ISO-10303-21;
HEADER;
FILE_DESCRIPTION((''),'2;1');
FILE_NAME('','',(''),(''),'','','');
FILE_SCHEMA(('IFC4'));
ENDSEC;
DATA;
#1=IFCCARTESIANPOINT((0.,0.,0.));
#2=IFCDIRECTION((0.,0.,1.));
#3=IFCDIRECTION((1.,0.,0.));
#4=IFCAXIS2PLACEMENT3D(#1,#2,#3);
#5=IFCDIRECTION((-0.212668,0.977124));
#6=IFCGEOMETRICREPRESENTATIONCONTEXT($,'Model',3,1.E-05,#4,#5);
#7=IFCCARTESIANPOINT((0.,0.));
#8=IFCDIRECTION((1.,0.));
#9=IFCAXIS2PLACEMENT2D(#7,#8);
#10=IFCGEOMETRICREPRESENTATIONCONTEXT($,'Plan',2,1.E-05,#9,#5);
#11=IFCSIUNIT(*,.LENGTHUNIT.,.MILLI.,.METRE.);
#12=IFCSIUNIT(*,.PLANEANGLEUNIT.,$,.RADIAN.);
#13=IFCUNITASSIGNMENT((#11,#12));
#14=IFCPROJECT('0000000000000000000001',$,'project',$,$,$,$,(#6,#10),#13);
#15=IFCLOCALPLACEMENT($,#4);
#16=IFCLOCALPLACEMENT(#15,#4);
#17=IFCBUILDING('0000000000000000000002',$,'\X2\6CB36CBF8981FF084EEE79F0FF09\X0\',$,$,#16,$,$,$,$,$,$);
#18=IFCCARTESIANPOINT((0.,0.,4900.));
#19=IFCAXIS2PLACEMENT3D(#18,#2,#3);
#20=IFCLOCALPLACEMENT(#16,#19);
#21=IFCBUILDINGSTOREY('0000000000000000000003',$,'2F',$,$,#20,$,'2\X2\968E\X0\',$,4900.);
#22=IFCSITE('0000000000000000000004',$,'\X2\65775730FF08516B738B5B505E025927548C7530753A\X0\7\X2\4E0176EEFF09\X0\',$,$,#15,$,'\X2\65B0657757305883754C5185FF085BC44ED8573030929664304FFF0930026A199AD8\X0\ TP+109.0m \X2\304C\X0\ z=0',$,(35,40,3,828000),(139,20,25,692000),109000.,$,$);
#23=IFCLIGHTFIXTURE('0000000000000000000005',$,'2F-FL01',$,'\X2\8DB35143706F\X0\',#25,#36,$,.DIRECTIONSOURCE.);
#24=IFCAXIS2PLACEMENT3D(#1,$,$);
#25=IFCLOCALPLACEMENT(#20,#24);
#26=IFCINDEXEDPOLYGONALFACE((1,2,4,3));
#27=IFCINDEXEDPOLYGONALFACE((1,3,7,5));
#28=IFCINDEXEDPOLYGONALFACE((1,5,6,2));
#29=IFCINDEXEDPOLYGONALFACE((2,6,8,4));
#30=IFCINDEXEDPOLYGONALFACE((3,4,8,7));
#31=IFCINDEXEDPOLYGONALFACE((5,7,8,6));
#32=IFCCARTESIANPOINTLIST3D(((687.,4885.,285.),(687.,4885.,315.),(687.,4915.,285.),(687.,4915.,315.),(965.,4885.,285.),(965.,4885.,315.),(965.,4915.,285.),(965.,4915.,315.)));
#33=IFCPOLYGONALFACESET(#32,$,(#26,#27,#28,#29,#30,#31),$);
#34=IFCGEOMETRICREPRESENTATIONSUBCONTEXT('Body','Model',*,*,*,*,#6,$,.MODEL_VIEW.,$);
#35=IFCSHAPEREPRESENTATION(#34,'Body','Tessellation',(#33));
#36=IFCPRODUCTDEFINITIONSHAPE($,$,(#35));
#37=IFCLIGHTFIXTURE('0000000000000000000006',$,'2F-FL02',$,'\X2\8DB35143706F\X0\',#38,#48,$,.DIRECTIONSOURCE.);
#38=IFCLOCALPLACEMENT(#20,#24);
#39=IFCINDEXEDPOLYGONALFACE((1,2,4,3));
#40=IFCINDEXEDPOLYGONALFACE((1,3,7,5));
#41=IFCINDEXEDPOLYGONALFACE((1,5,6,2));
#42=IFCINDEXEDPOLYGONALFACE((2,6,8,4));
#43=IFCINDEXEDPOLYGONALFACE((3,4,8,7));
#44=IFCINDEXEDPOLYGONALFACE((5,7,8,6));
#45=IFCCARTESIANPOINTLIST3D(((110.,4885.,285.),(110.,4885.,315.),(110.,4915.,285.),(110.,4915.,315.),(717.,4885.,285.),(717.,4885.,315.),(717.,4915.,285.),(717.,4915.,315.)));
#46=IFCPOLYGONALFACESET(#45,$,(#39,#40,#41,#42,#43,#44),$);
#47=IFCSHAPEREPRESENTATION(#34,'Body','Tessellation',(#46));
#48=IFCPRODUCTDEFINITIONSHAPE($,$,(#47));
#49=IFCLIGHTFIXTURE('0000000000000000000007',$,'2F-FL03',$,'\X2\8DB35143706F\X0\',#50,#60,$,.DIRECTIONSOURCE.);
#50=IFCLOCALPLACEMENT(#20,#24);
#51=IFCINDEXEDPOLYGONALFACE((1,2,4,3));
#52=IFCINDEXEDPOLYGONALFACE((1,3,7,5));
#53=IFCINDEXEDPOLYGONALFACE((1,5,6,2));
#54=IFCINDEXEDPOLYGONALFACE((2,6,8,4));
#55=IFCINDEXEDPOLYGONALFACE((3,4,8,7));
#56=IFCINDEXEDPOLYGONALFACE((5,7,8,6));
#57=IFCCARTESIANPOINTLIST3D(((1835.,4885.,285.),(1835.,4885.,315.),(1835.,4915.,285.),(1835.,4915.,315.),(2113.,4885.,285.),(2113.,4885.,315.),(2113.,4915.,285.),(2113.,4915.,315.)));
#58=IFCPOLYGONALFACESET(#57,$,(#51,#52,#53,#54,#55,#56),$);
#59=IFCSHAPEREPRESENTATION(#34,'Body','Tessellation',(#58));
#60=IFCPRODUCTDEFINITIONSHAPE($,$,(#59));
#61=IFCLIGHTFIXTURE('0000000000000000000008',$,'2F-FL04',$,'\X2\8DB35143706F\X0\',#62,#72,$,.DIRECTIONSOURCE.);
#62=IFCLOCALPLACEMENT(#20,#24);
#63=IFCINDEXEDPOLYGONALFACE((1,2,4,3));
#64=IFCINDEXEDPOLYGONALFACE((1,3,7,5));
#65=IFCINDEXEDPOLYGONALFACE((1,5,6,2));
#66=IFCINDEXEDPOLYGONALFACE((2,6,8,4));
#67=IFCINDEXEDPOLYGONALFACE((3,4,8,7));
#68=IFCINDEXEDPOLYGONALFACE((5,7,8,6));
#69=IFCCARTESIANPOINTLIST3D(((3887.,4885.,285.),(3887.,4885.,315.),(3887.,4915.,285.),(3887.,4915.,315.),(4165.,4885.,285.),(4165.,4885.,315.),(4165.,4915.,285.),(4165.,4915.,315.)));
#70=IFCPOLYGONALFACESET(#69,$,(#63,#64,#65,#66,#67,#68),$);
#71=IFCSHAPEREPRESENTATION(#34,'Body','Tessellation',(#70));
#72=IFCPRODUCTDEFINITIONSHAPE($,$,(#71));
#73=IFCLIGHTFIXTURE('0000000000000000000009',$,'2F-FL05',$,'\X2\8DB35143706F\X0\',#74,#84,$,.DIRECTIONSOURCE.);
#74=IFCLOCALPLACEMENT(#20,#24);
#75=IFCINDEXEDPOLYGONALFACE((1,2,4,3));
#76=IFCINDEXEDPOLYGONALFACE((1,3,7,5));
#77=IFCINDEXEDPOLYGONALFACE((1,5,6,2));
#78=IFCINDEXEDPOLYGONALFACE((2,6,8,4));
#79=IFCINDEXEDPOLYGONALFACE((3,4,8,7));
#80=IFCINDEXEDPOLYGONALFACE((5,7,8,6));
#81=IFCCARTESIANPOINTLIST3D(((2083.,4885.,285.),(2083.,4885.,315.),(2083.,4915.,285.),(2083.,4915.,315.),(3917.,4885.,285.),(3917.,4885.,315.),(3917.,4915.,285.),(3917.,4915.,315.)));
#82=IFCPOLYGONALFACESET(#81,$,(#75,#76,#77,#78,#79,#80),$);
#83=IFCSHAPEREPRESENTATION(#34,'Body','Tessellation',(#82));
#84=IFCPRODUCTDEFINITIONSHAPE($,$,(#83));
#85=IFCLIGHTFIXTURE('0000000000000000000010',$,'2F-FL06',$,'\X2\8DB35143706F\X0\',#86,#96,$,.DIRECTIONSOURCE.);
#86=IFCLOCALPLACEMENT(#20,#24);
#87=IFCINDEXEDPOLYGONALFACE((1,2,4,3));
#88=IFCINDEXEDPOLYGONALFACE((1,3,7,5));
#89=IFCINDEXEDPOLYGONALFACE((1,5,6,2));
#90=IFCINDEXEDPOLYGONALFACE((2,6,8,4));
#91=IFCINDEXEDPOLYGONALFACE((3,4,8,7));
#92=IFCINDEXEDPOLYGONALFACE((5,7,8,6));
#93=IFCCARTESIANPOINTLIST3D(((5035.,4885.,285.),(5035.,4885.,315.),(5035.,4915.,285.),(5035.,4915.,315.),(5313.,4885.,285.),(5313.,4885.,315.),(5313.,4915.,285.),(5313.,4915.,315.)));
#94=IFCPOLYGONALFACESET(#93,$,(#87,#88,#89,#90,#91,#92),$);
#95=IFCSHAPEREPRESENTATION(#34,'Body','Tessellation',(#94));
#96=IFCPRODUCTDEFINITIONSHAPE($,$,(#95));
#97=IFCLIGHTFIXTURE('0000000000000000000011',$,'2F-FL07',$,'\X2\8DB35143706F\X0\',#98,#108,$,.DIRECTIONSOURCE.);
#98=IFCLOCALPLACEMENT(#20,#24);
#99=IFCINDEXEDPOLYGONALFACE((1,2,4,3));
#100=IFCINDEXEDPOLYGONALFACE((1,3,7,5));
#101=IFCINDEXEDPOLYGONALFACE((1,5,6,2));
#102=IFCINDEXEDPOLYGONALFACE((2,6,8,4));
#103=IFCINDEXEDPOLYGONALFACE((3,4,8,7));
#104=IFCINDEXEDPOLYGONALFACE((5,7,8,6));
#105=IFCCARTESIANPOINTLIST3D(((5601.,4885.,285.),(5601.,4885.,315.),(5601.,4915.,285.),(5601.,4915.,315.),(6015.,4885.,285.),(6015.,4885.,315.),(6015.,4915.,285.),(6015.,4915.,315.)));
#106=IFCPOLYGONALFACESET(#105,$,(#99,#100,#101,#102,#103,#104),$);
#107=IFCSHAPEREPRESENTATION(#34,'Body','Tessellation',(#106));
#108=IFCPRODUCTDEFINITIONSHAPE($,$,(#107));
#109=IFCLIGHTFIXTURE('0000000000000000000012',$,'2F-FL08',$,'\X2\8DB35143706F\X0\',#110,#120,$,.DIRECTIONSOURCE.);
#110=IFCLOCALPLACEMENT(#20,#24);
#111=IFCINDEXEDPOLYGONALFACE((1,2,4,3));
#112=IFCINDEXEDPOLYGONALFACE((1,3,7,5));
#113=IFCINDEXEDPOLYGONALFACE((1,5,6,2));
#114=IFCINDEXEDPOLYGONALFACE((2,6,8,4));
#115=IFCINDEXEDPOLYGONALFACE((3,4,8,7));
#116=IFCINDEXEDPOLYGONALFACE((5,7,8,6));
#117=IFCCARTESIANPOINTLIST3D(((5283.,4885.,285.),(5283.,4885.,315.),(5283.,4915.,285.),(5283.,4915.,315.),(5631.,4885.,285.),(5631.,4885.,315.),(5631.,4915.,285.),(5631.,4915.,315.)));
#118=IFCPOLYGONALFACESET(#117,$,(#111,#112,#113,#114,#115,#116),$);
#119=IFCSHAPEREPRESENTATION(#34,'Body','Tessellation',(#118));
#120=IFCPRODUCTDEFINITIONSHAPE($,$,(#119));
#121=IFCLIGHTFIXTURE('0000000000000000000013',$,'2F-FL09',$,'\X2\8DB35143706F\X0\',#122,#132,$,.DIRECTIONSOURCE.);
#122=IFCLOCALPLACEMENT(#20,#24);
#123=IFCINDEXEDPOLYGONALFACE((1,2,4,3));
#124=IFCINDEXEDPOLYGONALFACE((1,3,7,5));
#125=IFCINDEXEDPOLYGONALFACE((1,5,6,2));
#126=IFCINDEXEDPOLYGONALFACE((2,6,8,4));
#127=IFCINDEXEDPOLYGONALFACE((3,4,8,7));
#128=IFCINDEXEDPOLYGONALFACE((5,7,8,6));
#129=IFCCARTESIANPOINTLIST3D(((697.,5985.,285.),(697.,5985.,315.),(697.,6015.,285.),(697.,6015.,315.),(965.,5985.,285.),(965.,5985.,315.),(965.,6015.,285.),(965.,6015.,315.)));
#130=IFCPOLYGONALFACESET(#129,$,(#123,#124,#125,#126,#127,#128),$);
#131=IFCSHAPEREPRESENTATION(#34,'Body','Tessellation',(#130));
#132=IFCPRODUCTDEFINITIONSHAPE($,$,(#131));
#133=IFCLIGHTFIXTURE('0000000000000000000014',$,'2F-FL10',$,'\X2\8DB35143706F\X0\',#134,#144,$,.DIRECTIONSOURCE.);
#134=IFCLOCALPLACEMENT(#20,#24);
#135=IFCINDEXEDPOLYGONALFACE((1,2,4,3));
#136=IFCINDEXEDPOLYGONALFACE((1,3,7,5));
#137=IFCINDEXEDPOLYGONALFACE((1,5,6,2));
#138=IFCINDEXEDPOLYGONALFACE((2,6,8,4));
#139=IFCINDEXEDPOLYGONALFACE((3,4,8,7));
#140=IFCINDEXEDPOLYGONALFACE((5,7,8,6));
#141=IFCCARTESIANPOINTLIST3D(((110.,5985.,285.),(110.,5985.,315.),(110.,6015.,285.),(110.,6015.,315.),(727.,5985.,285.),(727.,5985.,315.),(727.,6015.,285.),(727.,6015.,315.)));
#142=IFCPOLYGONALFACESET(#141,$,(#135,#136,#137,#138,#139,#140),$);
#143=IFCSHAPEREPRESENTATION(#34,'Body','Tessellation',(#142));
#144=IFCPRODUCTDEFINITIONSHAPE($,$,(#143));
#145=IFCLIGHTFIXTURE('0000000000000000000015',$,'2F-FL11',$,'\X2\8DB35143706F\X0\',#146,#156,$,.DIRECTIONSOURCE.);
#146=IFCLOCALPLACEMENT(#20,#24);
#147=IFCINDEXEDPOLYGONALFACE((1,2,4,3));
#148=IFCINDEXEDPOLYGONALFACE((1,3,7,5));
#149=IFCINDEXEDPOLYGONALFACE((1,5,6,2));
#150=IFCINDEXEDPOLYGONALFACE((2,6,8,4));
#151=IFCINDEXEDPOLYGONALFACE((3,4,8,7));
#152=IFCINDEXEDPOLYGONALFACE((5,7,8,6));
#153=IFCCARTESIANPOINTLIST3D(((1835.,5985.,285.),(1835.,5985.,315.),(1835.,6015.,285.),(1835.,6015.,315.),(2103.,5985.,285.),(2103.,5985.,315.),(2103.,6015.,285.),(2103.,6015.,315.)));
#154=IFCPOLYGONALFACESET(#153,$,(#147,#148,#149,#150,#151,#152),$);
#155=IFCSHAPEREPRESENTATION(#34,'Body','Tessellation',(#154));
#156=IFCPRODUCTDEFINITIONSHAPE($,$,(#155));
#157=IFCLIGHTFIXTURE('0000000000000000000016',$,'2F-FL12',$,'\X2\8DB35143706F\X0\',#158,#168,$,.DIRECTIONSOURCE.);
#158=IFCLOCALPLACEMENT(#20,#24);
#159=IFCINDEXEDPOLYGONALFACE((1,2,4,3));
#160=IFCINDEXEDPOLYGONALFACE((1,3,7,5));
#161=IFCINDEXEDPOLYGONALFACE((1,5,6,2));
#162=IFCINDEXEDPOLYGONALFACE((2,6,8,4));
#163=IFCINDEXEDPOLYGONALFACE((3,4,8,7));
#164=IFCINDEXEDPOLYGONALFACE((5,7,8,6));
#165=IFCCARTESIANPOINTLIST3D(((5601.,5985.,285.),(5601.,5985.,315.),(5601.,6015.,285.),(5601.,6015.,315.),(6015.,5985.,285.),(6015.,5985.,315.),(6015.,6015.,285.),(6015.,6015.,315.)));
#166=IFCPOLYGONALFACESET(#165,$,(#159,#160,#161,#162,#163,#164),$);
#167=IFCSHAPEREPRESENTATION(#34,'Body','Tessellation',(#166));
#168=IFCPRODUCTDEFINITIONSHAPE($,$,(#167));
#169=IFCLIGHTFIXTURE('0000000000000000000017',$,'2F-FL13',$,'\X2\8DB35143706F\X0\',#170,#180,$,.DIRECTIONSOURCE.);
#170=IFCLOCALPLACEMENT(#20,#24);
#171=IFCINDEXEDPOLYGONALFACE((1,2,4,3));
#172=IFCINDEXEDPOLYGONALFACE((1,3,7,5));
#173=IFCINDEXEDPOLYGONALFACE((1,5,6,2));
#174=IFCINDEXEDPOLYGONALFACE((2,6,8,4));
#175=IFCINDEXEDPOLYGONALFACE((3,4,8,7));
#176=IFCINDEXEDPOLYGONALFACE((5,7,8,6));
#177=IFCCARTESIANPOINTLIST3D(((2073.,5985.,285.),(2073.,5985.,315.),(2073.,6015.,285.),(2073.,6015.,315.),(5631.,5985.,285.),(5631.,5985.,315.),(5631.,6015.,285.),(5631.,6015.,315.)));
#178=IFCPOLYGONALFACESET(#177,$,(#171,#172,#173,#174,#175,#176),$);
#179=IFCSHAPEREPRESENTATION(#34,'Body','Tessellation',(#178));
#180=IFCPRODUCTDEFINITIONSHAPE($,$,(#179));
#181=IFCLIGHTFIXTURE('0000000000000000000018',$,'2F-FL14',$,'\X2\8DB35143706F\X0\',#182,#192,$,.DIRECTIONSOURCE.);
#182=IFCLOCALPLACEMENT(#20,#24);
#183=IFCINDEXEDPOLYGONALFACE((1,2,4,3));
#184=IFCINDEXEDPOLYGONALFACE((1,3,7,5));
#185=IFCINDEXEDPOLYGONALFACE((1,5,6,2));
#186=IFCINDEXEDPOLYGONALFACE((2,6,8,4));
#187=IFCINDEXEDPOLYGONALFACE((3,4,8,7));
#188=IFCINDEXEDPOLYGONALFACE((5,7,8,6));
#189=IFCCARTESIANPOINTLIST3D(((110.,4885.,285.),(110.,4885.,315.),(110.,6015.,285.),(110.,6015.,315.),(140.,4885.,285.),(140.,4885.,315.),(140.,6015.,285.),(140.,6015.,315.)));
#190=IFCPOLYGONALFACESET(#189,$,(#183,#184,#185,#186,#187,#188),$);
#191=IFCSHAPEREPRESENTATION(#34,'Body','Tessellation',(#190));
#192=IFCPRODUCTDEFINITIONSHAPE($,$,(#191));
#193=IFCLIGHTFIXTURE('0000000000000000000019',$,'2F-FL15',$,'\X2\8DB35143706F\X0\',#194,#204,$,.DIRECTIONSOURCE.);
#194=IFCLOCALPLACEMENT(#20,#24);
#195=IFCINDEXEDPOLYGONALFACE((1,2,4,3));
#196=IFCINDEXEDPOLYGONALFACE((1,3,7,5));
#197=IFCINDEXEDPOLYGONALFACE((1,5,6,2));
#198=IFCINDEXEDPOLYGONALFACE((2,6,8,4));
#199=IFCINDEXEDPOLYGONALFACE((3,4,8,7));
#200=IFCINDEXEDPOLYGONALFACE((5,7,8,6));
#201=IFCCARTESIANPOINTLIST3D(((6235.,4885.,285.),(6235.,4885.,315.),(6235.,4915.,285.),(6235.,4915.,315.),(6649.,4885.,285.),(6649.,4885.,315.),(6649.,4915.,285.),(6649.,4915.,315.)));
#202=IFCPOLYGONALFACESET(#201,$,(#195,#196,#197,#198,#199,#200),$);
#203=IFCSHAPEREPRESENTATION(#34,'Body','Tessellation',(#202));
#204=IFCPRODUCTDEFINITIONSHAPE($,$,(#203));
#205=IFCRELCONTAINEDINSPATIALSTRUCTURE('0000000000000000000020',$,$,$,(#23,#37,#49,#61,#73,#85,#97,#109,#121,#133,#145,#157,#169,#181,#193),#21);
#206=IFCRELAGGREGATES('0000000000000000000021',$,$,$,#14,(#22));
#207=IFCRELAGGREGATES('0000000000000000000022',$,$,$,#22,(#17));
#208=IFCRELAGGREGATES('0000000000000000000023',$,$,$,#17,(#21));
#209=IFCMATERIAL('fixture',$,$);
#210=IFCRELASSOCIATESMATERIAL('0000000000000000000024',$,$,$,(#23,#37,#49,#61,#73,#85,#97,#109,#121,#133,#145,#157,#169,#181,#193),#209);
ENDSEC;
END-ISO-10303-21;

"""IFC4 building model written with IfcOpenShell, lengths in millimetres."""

from ifc_helpers import new_model, si_unit, direction, frame, frame_2d, origin_with_axes, origin_2d_with_axis, place, context, subcontext, project, spatial, rectangle, extrude, material, element, save


model = new_model("IFC4")

# Units and contexts
model_context = context("Model", 3, precision=1e-05, world=origin_with_axes(), true_north=direction((-0.212668, 0.977124)))
plan_context = context("Plan", 2, precision=1e-05, world=origin_2d_with_axis(), true_north=direction((-0.212668, 0.977124)))
body_context = subcontext(model_context, "Body", "Model", "MODEL_VIEW")
ifc_project = project(units=[si_unit("LENGTHUNIT", "METRE", prefix="MILLI"), si_unit("PLANEANGLEUNIT", "RADIAN")], contexts=[model_context, plan_context])

# Site, building, storey
site_placement = place(None, origin_with_axes())
site = spatial("IfcSite", under=ifc_project, at=site_placement, Name="敷地（八王子市大和田町7丁目）", LongName="新敷地境界内（寄付地を除く）。標高 TP+109.0m が z=0", RefLatitude=(35, 40, 3, 828000), RefLongitude=(139, 20, 25, 692000), RefElevation=109000.0)
building_placement = place(site_placement, origin_with_axes())
building = spatial("IfcBuilding", under=site, at=building_placement, Name="河沿要（仮称）")
storey_placement = place(building_placement, frame((0.0, 0.0, 4900.0), z_axis=(0.0, 0.0, 1.0), x_axis=(1.0, 0.0, 0.0)))
storey = spatial("IfcBuildingStorey", under=building, at=storey_placement, Name="2F", LongName="2階", Elevation=4900.0)

# Light fixtures
ifc_material = material(Name="fixture")
light_fixture_1_placement = place(storey_placement, origin_with_axes())
element("IfcLightFixture", 1, at=light_fixture_1_placement, inside=storey, material=ifc_material, Name="2F-FL01", ObjectType="足元灯", PredefinedType="DIRECTIONSOURCE", context=body_context, shape_type="SweptSolid", body=[
    extrude(rectangle(XDim=278.0, YDim=30.0, at=frame_2d((826.0, 4900.0))), frame((0.0, 0.0, 285.0)), (0.0, 0.0, 1.0), 30.0),
])
light_fixture_2_placement = place(storey_placement, origin_with_axes())
element("IfcLightFixture", 2, at=light_fixture_2_placement, inside=storey, material=ifc_material, Name="2F-FL02", ObjectType="足元灯", PredefinedType="DIRECTIONSOURCE", context=body_context, shape_type="SweptSolid", body=[
    extrude(rectangle(XDim=607.0, YDim=30.0, at=frame_2d((413.5, 4900.0))), frame((0.0, 0.0, 285.0)), (0.0, 0.0, 1.0), 30.0),
])
light_fixture_3_placement = place(storey_placement, origin_with_axes())
element("IfcLightFixture", 3, at=light_fixture_3_placement, inside=storey, material=ifc_material, Name="2F-FL03", ObjectType="足元灯", PredefinedType="DIRECTIONSOURCE", context=body_context, shape_type="SweptSolid", body=[
    extrude(rectangle(XDim=278.0, YDim=30.0, at=frame_2d((1974.0, 4900.0))), frame((0.0, 0.0, 285.0)), (0.0, 0.0, 1.0), 30.0),
])
light_fixture_4_placement = place(storey_placement, origin_with_axes())
element("IfcLightFixture", 4, at=light_fixture_4_placement, inside=storey, material=ifc_material, Name="2F-FL04", ObjectType="足元灯", PredefinedType="DIRECTIONSOURCE", context=body_context, shape_type="SweptSolid", body=[
    extrude(rectangle(XDim=278.0, YDim=30.0, at=frame_2d((4026.0, 4900.0))), frame((0.0, 0.0, 285.0)), (0.0, 0.0, 1.0), 30.0),
])
light_fixture_5_placement = place(storey_placement, origin_with_axes())
element("IfcLightFixture", 5, at=light_fixture_5_placement, inside=storey, material=ifc_material, Name="2F-FL05", ObjectType="足元灯", PredefinedType="DIRECTIONSOURCE", context=body_context, shape_type="SweptSolid", body=[
    extrude(rectangle(XDim=1834.0, YDim=30.0, at=frame_2d((3000.0, 4900.0))), frame((0.0, 0.0, 285.0)), (0.0, 0.0, 1.0), 30.0),
])
light_fixture_6_placement = place(storey_placement, origin_with_axes())
element("IfcLightFixture", 6, at=light_fixture_6_placement, inside=storey, material=ifc_material, Name="2F-FL06", ObjectType="足元灯", PredefinedType="DIRECTIONSOURCE", context=body_context, shape_type="SweptSolid", body=[
    extrude(rectangle(XDim=278.0, YDim=30.0, at=frame_2d((5174.0, 4900.0))), frame((0.0, 0.0, 285.0)), (0.0, 0.0, 1.0), 30.0),
])
light_fixture_7_placement = place(storey_placement, origin_with_axes())
element("IfcLightFixture", 7, at=light_fixture_7_placement, inside=storey, material=ifc_material, Name="2F-FL07", ObjectType="足元灯", PredefinedType="DIRECTIONSOURCE", context=body_context, shape_type="SweptSolid", body=[
    extrude(rectangle(XDim=414.0, YDim=30.0, at=frame_2d((5808.0, 4900.0))), frame((0.0, 0.0, 285.0)), (0.0, 0.0, 1.0), 30.0),
])
light_fixture_8_placement = place(storey_placement, origin_with_axes())
element("IfcLightFixture", 8, at=light_fixture_8_placement, inside=storey, material=ifc_material, Name="2F-FL08", ObjectType="足元灯", PredefinedType="DIRECTIONSOURCE", context=body_context, shape_type="SweptSolid", body=[
    extrude(rectangle(XDim=348.0, YDim=30.0, at=frame_2d((5457.0, 4900.0))), frame((0.0, 0.0, 285.0)), (0.0, 0.0, 1.0), 30.0),
])
light_fixture_9_placement = place(storey_placement, origin_with_axes())
element("IfcLightFixture", 9, at=light_fixture_9_placement, inside=storey, material=ifc_material, Name="2F-FL09", ObjectType="足元灯", PredefinedType="DIRECTIONSOURCE", context=body_context, shape_type="SweptSolid", body=[
    extrude(rectangle(XDim=268.0, YDim=30.0, at=frame_2d((831.0, 6000.0))), frame((0.0, 0.0, 285.0)), (0.0, 0.0, 1.0), 30.0),
])
light_fixture_10_placement = place(storey_placement, origin_with_axes())
element("IfcLightFixture", 10, at=light_fixture_10_placement, inside=storey, material=ifc_material, Name="2F-FL10", ObjectType="足元灯", PredefinedType="DIRECTIONSOURCE", context=body_context, shape_type="SweptSolid", body=[
    extrude(rectangle(XDim=617.0, YDim=30.0, at=frame_2d((418.5, 6000.0))), frame((0.0, 0.0, 285.0)), (0.0, 0.0, 1.0), 30.0),
])
light_fixture_11_placement = place(storey_placement, origin_with_axes())
element("IfcLightFixture", 11, at=light_fixture_11_placement, inside=storey, material=ifc_material, Name="2F-FL11", ObjectType="足元灯", PredefinedType="DIRECTIONSOURCE", context=body_context, shape_type="SweptSolid", body=[
    extrude(rectangle(XDim=268.0, YDim=30.0, at=frame_2d((1969.0, 6000.0))), frame((0.0, 0.0, 285.0)), (0.0, 0.0, 1.0), 30.0),
])
light_fixture_12_placement = place(storey_placement, origin_with_axes())
element("IfcLightFixture", 12, at=light_fixture_12_placement, inside=storey, material=ifc_material, Name="2F-FL12", ObjectType="足元灯", PredefinedType="DIRECTIONSOURCE", context=body_context, shape_type="SweptSolid", body=[
    extrude(rectangle(XDim=414.0, YDim=30.0, at=frame_2d((5808.0, 6000.0))), frame((0.0, 0.0, 285.0)), (0.0, 0.0, 1.0), 30.0),
])
light_fixture_13_placement = place(storey_placement, origin_with_axes())
element("IfcLightFixture", 13, at=light_fixture_13_placement, inside=storey, material=ifc_material, Name="2F-FL13", ObjectType="足元灯", PredefinedType="DIRECTIONSOURCE", context=body_context, shape_type="SweptSolid", body=[
    extrude(rectangle(XDim=3558.0, YDim=30.0, at=frame_2d((3852.0, 6000.0))), frame((0.0, 0.0, 285.0)), (0.0, 0.0, 1.0), 30.0),
])
light_fixture_14_placement = place(storey_placement, origin_with_axes())
element("IfcLightFixture", 14, at=light_fixture_14_placement, inside=storey, material=ifc_material, Name="2F-FL14", ObjectType="足元灯", PredefinedType="DIRECTIONSOURCE", context=body_context, shape_type="SweptSolid", body=[
    extrude(rectangle(XDim=30.0, YDim=1130.0, at=frame_2d((125.0, 5450.0))), frame((0.0, 0.0, 285.0)), (0.0, 0.0, 1.0), 30.0),
])
light_fixture_15_placement = place(storey_placement, origin_with_axes())
element("IfcLightFixture", 15, at=light_fixture_15_placement, inside=storey, material=ifc_material, Name="2F-FL15", ObjectType="足元灯", PredefinedType="DIRECTIONSOURCE", context=body_context, shape_type="SweptSolid", body=[
    extrude(rectangle(XDim=414.0, YDim=30.0, at=frame_2d((6442.0, 4900.0))), frame((0.0, 0.0, 285.0)), (0.0, 0.0, 1.0), 30.0),
])

save(model, "model.ifc")
